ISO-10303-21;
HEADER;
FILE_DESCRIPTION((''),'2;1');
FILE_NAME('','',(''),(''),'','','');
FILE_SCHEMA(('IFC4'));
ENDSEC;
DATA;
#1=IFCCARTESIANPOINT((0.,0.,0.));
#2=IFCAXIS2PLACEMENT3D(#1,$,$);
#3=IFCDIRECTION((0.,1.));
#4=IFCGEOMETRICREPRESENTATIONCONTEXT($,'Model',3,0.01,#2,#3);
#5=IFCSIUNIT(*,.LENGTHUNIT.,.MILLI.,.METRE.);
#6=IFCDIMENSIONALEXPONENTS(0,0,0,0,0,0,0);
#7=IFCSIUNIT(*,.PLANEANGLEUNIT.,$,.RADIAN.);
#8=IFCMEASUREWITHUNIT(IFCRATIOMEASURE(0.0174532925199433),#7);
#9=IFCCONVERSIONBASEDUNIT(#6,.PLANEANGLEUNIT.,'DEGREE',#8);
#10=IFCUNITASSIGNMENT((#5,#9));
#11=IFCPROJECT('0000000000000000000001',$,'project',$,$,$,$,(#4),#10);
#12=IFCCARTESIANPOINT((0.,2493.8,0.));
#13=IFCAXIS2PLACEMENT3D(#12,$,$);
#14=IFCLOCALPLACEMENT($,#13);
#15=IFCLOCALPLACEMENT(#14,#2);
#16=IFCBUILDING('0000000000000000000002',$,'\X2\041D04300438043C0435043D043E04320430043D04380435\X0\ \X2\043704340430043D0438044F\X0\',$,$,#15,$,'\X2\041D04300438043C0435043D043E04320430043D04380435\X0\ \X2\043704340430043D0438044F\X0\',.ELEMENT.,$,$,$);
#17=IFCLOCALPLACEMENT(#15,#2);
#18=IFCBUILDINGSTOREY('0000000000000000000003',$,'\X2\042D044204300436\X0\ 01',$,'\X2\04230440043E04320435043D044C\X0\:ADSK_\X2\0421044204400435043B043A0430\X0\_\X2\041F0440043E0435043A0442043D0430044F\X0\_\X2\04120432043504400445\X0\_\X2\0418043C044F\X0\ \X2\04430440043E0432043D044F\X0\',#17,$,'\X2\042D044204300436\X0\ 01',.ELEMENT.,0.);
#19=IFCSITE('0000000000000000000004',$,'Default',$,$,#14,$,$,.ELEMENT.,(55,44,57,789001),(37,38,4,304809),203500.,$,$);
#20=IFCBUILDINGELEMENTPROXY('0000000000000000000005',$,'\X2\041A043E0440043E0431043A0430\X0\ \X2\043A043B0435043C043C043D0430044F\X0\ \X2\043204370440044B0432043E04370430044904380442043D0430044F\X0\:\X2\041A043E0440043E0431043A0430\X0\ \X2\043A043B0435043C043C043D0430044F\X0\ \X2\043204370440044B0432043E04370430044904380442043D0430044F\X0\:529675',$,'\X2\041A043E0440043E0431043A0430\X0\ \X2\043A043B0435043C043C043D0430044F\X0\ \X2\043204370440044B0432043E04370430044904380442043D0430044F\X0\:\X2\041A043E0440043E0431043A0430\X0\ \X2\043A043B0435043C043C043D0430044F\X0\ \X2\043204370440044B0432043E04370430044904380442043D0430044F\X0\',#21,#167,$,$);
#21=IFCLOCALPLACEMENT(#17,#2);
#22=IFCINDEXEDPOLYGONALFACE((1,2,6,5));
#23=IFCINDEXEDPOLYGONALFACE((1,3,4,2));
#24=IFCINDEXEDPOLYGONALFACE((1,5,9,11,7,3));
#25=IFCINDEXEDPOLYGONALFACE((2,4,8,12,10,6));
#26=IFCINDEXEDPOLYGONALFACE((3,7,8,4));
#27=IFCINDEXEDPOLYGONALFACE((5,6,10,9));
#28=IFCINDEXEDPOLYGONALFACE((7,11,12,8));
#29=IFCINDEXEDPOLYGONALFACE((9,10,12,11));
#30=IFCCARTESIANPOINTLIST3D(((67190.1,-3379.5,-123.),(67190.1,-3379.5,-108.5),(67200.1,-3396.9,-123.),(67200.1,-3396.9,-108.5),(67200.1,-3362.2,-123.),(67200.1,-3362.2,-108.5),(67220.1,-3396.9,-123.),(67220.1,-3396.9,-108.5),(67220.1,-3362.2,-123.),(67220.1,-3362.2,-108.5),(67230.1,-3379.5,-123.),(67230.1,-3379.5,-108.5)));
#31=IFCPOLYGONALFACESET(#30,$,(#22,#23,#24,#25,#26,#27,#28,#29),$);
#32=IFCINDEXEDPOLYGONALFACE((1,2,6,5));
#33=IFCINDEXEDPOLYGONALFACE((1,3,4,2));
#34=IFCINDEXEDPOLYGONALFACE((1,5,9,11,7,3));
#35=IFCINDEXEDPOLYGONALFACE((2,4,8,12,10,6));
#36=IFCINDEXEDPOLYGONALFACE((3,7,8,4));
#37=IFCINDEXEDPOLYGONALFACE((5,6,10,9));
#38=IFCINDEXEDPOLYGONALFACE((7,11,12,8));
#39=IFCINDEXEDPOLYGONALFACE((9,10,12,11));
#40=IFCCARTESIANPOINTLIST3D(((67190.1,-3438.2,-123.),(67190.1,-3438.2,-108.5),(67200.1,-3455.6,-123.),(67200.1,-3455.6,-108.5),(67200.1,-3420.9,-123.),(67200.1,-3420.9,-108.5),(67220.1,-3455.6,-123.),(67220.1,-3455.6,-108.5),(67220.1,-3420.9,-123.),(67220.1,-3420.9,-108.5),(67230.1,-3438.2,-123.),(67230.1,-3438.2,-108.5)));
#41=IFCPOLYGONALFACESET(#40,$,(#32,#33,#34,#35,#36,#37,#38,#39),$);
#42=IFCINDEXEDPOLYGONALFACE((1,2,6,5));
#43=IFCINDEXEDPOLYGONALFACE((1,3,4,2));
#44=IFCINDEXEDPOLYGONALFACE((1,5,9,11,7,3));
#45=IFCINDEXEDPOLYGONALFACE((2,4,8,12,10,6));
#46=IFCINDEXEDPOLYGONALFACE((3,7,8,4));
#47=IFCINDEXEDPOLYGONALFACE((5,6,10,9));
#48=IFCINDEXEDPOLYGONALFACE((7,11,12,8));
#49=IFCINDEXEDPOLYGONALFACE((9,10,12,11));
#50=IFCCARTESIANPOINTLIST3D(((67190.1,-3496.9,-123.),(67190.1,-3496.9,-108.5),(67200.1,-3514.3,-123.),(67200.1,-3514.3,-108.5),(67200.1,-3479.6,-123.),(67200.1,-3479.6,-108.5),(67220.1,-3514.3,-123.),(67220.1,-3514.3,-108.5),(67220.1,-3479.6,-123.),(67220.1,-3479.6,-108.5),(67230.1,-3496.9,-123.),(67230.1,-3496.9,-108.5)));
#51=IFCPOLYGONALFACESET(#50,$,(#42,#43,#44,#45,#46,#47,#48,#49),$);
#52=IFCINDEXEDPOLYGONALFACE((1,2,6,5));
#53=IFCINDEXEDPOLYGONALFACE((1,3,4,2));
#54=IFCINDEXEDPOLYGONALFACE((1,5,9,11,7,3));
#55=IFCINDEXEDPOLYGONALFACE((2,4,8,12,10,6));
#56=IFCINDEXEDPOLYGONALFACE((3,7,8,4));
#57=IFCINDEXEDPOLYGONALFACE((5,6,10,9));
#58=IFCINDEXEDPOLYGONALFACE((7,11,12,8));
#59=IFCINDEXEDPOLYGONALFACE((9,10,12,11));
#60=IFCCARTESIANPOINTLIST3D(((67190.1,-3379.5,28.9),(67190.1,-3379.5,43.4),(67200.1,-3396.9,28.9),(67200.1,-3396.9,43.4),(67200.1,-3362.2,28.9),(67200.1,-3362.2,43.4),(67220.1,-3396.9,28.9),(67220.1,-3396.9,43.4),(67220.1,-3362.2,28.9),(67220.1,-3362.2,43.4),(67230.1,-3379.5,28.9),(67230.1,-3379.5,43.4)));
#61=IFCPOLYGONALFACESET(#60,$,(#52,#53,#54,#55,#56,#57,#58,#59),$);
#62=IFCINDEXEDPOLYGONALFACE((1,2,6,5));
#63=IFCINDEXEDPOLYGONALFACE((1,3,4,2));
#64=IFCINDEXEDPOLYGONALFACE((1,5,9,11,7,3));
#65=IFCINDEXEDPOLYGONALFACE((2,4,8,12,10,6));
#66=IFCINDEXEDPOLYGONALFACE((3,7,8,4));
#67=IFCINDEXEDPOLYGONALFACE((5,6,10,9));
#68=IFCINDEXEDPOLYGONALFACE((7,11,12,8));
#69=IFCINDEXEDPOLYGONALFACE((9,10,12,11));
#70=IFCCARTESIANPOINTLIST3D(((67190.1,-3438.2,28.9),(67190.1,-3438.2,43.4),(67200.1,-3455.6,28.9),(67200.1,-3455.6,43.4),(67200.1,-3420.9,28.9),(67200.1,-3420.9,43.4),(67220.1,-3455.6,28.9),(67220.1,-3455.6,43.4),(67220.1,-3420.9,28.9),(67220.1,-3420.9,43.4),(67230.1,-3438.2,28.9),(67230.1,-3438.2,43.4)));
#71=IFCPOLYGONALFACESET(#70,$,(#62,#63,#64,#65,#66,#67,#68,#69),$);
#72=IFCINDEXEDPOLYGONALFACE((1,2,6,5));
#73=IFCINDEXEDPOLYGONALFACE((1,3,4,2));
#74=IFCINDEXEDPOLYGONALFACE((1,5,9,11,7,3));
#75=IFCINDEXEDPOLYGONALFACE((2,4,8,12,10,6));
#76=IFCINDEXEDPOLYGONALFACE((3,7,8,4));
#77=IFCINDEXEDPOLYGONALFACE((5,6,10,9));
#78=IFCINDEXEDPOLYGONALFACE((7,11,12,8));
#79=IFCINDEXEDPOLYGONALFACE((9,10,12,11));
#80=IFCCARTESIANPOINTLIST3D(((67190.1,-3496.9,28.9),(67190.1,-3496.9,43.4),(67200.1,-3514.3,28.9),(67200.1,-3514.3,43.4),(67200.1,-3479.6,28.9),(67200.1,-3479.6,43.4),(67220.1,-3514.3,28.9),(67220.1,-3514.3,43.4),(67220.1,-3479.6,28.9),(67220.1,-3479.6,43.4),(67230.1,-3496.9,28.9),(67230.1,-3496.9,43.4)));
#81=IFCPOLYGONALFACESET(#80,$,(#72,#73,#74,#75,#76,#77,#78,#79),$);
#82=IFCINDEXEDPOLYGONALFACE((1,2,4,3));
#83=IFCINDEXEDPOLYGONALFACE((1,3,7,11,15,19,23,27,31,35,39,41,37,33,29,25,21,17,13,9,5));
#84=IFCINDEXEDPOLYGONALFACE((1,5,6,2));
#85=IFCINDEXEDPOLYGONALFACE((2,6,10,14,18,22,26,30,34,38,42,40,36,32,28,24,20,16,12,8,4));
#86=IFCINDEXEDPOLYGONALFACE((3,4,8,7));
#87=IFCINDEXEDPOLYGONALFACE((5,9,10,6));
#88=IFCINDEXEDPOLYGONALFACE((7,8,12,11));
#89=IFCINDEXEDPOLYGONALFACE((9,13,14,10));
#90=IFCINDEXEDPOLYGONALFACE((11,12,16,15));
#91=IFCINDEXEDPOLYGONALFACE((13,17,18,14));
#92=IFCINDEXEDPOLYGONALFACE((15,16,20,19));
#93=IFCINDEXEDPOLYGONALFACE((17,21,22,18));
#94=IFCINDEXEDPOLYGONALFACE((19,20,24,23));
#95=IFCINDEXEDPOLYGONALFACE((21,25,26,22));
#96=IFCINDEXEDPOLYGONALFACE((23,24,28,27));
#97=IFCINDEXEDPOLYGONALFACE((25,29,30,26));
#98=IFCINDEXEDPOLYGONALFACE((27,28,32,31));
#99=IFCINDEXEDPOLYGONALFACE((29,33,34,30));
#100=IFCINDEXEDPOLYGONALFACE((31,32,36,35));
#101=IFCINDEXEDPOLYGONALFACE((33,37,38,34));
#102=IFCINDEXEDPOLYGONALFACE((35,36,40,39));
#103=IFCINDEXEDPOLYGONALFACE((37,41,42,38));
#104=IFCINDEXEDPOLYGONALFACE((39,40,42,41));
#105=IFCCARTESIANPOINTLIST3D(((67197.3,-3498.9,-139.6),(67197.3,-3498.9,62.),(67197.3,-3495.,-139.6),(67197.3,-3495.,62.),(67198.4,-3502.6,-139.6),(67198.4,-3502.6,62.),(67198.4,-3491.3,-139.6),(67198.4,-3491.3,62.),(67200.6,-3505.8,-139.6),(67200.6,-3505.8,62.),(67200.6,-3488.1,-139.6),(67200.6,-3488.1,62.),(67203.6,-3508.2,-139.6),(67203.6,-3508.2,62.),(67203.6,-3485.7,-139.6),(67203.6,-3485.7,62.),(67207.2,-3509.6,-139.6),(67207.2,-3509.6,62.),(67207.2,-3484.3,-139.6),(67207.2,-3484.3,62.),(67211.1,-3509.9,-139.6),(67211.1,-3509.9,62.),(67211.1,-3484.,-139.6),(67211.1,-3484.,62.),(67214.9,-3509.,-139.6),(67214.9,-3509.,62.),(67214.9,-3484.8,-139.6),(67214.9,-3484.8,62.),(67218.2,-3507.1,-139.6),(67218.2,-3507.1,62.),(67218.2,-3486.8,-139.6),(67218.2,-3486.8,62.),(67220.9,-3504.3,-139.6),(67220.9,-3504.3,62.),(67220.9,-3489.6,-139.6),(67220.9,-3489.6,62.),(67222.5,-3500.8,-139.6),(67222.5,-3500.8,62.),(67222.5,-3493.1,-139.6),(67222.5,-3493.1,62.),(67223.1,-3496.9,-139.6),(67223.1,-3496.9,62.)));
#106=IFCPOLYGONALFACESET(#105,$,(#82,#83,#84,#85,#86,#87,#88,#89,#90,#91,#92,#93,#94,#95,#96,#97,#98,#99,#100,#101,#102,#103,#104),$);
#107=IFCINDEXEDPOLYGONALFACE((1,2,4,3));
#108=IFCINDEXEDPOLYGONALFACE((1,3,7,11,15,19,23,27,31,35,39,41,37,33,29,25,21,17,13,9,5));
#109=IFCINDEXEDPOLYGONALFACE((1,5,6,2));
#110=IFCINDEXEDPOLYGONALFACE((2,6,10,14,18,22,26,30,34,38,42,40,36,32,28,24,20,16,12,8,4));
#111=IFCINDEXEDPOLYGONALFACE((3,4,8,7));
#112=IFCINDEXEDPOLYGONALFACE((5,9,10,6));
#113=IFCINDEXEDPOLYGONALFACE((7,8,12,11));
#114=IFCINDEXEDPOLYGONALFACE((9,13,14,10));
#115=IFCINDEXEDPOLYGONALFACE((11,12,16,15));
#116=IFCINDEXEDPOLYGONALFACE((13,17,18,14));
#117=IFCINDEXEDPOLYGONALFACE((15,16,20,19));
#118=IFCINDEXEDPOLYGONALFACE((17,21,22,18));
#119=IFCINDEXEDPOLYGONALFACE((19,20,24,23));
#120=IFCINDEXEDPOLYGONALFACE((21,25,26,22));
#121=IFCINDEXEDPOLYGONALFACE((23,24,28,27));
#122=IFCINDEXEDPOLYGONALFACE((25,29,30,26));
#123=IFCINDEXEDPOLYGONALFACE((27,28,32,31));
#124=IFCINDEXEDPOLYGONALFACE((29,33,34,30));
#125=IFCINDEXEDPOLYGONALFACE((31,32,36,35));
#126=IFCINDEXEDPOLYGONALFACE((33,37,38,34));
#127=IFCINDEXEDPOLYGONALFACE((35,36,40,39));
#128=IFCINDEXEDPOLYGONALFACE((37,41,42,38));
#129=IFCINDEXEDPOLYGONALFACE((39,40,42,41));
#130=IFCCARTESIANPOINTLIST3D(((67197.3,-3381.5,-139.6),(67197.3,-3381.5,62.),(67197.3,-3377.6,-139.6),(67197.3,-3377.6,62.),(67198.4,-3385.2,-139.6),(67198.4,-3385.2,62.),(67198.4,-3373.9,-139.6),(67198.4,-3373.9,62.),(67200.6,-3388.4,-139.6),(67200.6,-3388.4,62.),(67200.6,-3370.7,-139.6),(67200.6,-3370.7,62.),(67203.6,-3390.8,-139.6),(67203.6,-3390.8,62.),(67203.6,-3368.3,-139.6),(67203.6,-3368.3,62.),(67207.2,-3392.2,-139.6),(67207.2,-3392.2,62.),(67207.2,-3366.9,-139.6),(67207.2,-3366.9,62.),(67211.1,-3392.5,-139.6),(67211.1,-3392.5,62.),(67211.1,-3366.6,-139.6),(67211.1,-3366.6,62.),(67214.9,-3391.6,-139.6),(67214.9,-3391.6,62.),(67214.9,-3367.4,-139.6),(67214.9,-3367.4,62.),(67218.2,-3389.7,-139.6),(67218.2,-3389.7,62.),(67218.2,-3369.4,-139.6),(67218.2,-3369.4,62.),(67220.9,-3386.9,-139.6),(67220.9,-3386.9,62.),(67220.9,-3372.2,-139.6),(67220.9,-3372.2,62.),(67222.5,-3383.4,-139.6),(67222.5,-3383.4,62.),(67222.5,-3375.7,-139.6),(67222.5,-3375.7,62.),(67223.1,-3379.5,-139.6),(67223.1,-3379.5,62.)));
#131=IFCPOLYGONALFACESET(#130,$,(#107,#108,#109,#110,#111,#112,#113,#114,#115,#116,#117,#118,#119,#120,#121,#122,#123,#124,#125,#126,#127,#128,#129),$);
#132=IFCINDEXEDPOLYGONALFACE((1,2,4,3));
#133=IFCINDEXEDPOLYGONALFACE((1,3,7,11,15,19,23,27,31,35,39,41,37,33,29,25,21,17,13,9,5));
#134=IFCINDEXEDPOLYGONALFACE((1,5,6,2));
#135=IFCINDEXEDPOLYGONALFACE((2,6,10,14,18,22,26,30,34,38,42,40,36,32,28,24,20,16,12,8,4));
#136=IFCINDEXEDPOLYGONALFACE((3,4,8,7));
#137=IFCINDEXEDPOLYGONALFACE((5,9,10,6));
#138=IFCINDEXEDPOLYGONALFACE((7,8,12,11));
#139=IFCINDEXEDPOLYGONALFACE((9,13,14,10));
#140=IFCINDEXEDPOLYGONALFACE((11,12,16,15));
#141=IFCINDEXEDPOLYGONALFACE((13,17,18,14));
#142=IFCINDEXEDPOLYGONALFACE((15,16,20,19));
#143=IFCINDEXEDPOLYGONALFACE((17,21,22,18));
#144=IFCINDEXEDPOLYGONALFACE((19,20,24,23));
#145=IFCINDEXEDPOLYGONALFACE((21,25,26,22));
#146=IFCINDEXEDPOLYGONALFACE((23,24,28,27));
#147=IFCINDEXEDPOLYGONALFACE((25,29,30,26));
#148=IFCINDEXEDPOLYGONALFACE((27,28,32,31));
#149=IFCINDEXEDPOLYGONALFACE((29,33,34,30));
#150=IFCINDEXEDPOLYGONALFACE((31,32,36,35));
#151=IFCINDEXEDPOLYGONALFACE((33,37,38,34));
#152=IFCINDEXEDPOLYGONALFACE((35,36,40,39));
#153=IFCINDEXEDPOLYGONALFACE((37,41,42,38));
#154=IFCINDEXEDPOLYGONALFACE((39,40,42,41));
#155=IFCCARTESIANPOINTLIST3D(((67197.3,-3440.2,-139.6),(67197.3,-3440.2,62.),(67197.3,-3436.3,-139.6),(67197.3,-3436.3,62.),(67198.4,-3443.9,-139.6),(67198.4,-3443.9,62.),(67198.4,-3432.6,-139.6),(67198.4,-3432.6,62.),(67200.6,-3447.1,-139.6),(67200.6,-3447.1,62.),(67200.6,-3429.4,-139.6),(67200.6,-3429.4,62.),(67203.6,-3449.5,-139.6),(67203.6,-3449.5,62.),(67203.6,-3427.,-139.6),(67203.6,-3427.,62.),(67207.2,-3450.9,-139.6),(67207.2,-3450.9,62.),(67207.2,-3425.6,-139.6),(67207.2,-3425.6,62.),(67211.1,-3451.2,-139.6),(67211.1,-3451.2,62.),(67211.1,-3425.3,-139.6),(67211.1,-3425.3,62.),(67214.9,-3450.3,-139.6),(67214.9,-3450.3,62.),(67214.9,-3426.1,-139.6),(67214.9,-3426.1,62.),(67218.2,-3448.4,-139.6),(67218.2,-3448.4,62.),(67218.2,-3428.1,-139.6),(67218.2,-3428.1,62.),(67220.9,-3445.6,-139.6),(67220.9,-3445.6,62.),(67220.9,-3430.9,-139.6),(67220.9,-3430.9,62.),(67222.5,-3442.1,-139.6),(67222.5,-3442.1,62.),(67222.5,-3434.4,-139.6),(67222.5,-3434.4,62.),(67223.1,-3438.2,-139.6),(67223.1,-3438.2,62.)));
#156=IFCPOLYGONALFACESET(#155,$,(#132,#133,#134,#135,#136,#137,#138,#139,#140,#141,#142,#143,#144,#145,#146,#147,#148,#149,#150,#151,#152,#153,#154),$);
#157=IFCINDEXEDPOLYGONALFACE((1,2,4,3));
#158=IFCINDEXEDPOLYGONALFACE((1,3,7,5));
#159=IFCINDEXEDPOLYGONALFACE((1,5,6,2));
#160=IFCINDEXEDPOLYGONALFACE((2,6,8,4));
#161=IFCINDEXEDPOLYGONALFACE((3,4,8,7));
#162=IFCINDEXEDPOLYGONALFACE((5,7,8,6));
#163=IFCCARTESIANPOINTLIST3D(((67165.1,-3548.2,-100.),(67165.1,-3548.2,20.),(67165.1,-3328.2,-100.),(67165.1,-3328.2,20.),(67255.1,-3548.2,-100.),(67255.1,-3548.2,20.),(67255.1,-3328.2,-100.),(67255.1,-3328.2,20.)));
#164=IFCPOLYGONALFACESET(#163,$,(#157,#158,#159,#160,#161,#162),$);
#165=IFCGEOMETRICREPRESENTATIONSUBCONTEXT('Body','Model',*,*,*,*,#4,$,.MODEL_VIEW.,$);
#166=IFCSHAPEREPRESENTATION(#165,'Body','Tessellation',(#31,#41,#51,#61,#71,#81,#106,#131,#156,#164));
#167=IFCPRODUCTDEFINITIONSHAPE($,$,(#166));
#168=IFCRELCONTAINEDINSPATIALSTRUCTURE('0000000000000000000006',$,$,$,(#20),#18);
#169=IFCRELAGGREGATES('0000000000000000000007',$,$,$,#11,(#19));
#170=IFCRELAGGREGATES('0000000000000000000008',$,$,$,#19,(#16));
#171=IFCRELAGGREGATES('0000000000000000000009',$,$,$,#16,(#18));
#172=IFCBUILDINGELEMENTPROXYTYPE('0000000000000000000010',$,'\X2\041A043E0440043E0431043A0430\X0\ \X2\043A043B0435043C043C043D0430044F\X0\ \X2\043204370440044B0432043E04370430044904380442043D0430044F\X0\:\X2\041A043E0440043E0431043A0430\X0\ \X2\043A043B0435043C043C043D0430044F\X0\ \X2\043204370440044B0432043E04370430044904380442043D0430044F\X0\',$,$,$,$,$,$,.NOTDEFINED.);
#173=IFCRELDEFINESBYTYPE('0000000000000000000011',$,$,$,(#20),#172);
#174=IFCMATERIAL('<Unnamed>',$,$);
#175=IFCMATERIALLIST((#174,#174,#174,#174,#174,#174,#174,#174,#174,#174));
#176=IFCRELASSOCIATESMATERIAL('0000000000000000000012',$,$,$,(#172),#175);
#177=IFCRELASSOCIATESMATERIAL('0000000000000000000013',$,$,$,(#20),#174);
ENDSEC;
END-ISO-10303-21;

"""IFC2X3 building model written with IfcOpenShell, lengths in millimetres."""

from ifc_helpers import new_model, entity, si_unit, converted_unit, direction, frame, frame_2d, origin, place, context, subcontext, project, spatial, polyline, rectangle, circle, outline, extrude, source, transform, mapped, material, material_list, type_object, type_shapes, element, save


model = new_model("IFC2X3")

# Units and contexts
model_context = context("Model", 3, precision=0.01, world=origin(), true_north=direction((0.0, 1.0)))
body_context = subcontext(model_context, "Body", "Model", "MODEL_VIEW")
ifc_project = project(units=[si_unit("LENGTHUNIT", "METRE", prefix="MILLI"), converted_unit("PLANEANGLEUNIT", "DEGREE", entity("IfcRatioMeasure", 0.0174532925199433), si_unit("PLANEANGLEUNIT", "RADIAN"), dimensions=[0, 0, 0, 0, 0, 0, 0])], contexts=[model_context])

# Site, building, storey
site_placement = place(None, frame((0.0, 2493.8, 0.0)))
site = spatial("IfcSite", under=ifc_project, at=site_placement, Name="Default", CompositionType="ELEMENT", RefLatitude=(55, 44, 57, 789001), RefLongitude=(37, 38, 4, 304809), RefElevation=203500.0)
building_placement = place(site_placement, origin())
building = spatial("IfcBuilding", under=site, at=building_placement, Name="Наименование здания", LongName="Наименование здания", CompositionType="ELEMENT")
storey_placement = place(building_placement, origin())
storey = spatial("IfcBuildingStorey", under=building, at=storey_placement, Name="Этаж 01", ObjectType="Уровень:ADSK_Стрелка_Проектная_Вверх_Имя уровня", LongName="Этаж 01", CompositionType="ELEMENT", Elevation=0.0)

# Building element proxy
ifc_material_1 = material(Name="<Unnamed>")
ifc_material_list_1 = material_list([ifc_material_1, ifc_material_1, ifc_material_1, ifc_material_1, ifc_material_1, ifc_material_1, ifc_material_1, ifc_material_1, ifc_material_1, ifc_material_1])
building_element_proxy_type_1 = type_object("IfcBuildingElementProxyType", Name="Коробка клеммная взрывозащитная:Коробка клеммная взрывозащитная", PredefinedType="NOTDEFINED", material=ifc_material_list_1)
shared_shape_1 = source(origin(), body_context, "Body", "SweptSolid", [
    extrude(outline(polyline([(-10.0, -17.3), (10.0, -17.3), (20.0, 0.0), (10.0, 17.3), (-10.0, 17.3), (-20.0, 0.0), (-10.0, -17.3)])), frame((0.0, 58.7, -23.0), z_axis=(0.0, 0.0, 1.0), x_axis=(-1.0, 0.0, 0.0)), (0.0, 0.0, 1.0), 14.4),
    extrude(outline(polyline([(-10.0, -17.3), (10.0, -17.3), (20.0, 0.0), (10.0, 17.3), (-10.0, 17.3), (-20.0, 0.0), (-10.0, -17.3)])), frame((0.0, 0.0, -23.0), z_axis=(0.0, 0.0, 1.0), x_axis=(-1.0, 0.0, 0.0)), (0.0, 0.0, 1.0), 14.4),
    extrude(outline(polyline([(-10.0, -17.3), (10.0, -17.3), (20.0, 0.0), (10.0, 17.3), (-10.0, 17.3), (-20.0, 0.0), (-10.0, -17.3)])), frame((0.0, -58.7, -23.0), z_axis=(0.0, 0.0, 1.0), x_axis=(-1.0, 0.0, 0.0)), (0.0, 0.0, 1.0), 14.4),
    extrude(outline(polyline([(-10.0, -17.3), (10.0, -17.3), (20.0, 0.0), (10.0, 17.3), (-10.0, 17.3), (-20.0, 0.0), (-10.0, -17.3)])), frame((0.0, 58.7, 128.9), z_axis=(0.0, 0.0, 1.0), x_axis=(-1.0, 0.0, 0.0)), (0.0, 0.0, 1.0), 14.4),
    extrude(outline(polyline([(-10.0, -17.3), (10.0, -17.3), (20.0, 0.0), (10.0, 17.3), (-10.0, 17.3), (-20.0, 0.0), (-10.0, -17.3)])), frame((0.0, 0.0, 128.9), z_axis=(0.0, 0.0, 1.0), x_axis=(-1.0, 0.0, 0.0)), (0.0, 0.0, 1.0), 14.4),
    extrude(outline(polyline([(-10.0, -17.3), (10.0, -17.3), (20.0, 0.0), (10.0, 17.3), (-10.0, 17.3), (-20.0, 0.0), (-10.0, -17.3)])), frame((0.0, -58.7, 128.9), z_axis=(0.0, 0.0, 1.0), x_axis=(-1.0, 0.0, 0.0)), (0.0, 0.0, 1.0), 14.4),
    extrude(circle(Radius=13.0, at=frame_2d((0.0, 0.0), x_axis=(1.0, 0.0))), frame((0.0, -58.7, -39.6)), (0.0, 0.0, 1.0), 201.6),
    extrude(circle(Radius=13.0, at=frame_2d((0.0, 0.0), x_axis=(1.0, 0.0))), frame((0.0, 58.7, -39.6)), (0.0, 0.0, 1.0), 201.6),
    extrude(circle(Radius=13.0, at=frame_2d((0.0, 0.0), x_axis=(1.0, 0.0))), frame((0.0, 0.0, -39.6)), (0.0, 0.0, 1.0), 201.6),
    extrude(rectangle(XDim=220.0, YDim=90.0, at=frame_2d((0.0, 0.0), x_axis=(1.0, 0.0))), frame((0.0, 0.0, 0.0), z_axis=(0.0, 0.0, 1.0), x_axis=(0.0, -1.0, 0.0)), (0.0, 0.0, 1.0), 120.0),
])
type_shapes(building_element_proxy_type_1, [shared_shape_1])
for number, where, name in (
    (1, (67210.1, -3438.2, -100.0), "Коробка клеммная взрывозащитная:Коробка клеммная взрывозащитная:529675"),
):
    element("IfcBuildingElementProxy", number, at=place(storey_placement, frame(where)), inside=storey, type_object=building_element_proxy_type_1, material=ifc_material_1, Name=name, ObjectType="Коробка клеммная взрывозащитная:Коробка клеммная взрывозащитная", context=body_context, shape_type="MappedRepresentation", body=[
        mapped(shared_shape_1, transform((0.0, 0.0, 0.0), scale=1.0)),
    ])

save(model, "model.ifc")
